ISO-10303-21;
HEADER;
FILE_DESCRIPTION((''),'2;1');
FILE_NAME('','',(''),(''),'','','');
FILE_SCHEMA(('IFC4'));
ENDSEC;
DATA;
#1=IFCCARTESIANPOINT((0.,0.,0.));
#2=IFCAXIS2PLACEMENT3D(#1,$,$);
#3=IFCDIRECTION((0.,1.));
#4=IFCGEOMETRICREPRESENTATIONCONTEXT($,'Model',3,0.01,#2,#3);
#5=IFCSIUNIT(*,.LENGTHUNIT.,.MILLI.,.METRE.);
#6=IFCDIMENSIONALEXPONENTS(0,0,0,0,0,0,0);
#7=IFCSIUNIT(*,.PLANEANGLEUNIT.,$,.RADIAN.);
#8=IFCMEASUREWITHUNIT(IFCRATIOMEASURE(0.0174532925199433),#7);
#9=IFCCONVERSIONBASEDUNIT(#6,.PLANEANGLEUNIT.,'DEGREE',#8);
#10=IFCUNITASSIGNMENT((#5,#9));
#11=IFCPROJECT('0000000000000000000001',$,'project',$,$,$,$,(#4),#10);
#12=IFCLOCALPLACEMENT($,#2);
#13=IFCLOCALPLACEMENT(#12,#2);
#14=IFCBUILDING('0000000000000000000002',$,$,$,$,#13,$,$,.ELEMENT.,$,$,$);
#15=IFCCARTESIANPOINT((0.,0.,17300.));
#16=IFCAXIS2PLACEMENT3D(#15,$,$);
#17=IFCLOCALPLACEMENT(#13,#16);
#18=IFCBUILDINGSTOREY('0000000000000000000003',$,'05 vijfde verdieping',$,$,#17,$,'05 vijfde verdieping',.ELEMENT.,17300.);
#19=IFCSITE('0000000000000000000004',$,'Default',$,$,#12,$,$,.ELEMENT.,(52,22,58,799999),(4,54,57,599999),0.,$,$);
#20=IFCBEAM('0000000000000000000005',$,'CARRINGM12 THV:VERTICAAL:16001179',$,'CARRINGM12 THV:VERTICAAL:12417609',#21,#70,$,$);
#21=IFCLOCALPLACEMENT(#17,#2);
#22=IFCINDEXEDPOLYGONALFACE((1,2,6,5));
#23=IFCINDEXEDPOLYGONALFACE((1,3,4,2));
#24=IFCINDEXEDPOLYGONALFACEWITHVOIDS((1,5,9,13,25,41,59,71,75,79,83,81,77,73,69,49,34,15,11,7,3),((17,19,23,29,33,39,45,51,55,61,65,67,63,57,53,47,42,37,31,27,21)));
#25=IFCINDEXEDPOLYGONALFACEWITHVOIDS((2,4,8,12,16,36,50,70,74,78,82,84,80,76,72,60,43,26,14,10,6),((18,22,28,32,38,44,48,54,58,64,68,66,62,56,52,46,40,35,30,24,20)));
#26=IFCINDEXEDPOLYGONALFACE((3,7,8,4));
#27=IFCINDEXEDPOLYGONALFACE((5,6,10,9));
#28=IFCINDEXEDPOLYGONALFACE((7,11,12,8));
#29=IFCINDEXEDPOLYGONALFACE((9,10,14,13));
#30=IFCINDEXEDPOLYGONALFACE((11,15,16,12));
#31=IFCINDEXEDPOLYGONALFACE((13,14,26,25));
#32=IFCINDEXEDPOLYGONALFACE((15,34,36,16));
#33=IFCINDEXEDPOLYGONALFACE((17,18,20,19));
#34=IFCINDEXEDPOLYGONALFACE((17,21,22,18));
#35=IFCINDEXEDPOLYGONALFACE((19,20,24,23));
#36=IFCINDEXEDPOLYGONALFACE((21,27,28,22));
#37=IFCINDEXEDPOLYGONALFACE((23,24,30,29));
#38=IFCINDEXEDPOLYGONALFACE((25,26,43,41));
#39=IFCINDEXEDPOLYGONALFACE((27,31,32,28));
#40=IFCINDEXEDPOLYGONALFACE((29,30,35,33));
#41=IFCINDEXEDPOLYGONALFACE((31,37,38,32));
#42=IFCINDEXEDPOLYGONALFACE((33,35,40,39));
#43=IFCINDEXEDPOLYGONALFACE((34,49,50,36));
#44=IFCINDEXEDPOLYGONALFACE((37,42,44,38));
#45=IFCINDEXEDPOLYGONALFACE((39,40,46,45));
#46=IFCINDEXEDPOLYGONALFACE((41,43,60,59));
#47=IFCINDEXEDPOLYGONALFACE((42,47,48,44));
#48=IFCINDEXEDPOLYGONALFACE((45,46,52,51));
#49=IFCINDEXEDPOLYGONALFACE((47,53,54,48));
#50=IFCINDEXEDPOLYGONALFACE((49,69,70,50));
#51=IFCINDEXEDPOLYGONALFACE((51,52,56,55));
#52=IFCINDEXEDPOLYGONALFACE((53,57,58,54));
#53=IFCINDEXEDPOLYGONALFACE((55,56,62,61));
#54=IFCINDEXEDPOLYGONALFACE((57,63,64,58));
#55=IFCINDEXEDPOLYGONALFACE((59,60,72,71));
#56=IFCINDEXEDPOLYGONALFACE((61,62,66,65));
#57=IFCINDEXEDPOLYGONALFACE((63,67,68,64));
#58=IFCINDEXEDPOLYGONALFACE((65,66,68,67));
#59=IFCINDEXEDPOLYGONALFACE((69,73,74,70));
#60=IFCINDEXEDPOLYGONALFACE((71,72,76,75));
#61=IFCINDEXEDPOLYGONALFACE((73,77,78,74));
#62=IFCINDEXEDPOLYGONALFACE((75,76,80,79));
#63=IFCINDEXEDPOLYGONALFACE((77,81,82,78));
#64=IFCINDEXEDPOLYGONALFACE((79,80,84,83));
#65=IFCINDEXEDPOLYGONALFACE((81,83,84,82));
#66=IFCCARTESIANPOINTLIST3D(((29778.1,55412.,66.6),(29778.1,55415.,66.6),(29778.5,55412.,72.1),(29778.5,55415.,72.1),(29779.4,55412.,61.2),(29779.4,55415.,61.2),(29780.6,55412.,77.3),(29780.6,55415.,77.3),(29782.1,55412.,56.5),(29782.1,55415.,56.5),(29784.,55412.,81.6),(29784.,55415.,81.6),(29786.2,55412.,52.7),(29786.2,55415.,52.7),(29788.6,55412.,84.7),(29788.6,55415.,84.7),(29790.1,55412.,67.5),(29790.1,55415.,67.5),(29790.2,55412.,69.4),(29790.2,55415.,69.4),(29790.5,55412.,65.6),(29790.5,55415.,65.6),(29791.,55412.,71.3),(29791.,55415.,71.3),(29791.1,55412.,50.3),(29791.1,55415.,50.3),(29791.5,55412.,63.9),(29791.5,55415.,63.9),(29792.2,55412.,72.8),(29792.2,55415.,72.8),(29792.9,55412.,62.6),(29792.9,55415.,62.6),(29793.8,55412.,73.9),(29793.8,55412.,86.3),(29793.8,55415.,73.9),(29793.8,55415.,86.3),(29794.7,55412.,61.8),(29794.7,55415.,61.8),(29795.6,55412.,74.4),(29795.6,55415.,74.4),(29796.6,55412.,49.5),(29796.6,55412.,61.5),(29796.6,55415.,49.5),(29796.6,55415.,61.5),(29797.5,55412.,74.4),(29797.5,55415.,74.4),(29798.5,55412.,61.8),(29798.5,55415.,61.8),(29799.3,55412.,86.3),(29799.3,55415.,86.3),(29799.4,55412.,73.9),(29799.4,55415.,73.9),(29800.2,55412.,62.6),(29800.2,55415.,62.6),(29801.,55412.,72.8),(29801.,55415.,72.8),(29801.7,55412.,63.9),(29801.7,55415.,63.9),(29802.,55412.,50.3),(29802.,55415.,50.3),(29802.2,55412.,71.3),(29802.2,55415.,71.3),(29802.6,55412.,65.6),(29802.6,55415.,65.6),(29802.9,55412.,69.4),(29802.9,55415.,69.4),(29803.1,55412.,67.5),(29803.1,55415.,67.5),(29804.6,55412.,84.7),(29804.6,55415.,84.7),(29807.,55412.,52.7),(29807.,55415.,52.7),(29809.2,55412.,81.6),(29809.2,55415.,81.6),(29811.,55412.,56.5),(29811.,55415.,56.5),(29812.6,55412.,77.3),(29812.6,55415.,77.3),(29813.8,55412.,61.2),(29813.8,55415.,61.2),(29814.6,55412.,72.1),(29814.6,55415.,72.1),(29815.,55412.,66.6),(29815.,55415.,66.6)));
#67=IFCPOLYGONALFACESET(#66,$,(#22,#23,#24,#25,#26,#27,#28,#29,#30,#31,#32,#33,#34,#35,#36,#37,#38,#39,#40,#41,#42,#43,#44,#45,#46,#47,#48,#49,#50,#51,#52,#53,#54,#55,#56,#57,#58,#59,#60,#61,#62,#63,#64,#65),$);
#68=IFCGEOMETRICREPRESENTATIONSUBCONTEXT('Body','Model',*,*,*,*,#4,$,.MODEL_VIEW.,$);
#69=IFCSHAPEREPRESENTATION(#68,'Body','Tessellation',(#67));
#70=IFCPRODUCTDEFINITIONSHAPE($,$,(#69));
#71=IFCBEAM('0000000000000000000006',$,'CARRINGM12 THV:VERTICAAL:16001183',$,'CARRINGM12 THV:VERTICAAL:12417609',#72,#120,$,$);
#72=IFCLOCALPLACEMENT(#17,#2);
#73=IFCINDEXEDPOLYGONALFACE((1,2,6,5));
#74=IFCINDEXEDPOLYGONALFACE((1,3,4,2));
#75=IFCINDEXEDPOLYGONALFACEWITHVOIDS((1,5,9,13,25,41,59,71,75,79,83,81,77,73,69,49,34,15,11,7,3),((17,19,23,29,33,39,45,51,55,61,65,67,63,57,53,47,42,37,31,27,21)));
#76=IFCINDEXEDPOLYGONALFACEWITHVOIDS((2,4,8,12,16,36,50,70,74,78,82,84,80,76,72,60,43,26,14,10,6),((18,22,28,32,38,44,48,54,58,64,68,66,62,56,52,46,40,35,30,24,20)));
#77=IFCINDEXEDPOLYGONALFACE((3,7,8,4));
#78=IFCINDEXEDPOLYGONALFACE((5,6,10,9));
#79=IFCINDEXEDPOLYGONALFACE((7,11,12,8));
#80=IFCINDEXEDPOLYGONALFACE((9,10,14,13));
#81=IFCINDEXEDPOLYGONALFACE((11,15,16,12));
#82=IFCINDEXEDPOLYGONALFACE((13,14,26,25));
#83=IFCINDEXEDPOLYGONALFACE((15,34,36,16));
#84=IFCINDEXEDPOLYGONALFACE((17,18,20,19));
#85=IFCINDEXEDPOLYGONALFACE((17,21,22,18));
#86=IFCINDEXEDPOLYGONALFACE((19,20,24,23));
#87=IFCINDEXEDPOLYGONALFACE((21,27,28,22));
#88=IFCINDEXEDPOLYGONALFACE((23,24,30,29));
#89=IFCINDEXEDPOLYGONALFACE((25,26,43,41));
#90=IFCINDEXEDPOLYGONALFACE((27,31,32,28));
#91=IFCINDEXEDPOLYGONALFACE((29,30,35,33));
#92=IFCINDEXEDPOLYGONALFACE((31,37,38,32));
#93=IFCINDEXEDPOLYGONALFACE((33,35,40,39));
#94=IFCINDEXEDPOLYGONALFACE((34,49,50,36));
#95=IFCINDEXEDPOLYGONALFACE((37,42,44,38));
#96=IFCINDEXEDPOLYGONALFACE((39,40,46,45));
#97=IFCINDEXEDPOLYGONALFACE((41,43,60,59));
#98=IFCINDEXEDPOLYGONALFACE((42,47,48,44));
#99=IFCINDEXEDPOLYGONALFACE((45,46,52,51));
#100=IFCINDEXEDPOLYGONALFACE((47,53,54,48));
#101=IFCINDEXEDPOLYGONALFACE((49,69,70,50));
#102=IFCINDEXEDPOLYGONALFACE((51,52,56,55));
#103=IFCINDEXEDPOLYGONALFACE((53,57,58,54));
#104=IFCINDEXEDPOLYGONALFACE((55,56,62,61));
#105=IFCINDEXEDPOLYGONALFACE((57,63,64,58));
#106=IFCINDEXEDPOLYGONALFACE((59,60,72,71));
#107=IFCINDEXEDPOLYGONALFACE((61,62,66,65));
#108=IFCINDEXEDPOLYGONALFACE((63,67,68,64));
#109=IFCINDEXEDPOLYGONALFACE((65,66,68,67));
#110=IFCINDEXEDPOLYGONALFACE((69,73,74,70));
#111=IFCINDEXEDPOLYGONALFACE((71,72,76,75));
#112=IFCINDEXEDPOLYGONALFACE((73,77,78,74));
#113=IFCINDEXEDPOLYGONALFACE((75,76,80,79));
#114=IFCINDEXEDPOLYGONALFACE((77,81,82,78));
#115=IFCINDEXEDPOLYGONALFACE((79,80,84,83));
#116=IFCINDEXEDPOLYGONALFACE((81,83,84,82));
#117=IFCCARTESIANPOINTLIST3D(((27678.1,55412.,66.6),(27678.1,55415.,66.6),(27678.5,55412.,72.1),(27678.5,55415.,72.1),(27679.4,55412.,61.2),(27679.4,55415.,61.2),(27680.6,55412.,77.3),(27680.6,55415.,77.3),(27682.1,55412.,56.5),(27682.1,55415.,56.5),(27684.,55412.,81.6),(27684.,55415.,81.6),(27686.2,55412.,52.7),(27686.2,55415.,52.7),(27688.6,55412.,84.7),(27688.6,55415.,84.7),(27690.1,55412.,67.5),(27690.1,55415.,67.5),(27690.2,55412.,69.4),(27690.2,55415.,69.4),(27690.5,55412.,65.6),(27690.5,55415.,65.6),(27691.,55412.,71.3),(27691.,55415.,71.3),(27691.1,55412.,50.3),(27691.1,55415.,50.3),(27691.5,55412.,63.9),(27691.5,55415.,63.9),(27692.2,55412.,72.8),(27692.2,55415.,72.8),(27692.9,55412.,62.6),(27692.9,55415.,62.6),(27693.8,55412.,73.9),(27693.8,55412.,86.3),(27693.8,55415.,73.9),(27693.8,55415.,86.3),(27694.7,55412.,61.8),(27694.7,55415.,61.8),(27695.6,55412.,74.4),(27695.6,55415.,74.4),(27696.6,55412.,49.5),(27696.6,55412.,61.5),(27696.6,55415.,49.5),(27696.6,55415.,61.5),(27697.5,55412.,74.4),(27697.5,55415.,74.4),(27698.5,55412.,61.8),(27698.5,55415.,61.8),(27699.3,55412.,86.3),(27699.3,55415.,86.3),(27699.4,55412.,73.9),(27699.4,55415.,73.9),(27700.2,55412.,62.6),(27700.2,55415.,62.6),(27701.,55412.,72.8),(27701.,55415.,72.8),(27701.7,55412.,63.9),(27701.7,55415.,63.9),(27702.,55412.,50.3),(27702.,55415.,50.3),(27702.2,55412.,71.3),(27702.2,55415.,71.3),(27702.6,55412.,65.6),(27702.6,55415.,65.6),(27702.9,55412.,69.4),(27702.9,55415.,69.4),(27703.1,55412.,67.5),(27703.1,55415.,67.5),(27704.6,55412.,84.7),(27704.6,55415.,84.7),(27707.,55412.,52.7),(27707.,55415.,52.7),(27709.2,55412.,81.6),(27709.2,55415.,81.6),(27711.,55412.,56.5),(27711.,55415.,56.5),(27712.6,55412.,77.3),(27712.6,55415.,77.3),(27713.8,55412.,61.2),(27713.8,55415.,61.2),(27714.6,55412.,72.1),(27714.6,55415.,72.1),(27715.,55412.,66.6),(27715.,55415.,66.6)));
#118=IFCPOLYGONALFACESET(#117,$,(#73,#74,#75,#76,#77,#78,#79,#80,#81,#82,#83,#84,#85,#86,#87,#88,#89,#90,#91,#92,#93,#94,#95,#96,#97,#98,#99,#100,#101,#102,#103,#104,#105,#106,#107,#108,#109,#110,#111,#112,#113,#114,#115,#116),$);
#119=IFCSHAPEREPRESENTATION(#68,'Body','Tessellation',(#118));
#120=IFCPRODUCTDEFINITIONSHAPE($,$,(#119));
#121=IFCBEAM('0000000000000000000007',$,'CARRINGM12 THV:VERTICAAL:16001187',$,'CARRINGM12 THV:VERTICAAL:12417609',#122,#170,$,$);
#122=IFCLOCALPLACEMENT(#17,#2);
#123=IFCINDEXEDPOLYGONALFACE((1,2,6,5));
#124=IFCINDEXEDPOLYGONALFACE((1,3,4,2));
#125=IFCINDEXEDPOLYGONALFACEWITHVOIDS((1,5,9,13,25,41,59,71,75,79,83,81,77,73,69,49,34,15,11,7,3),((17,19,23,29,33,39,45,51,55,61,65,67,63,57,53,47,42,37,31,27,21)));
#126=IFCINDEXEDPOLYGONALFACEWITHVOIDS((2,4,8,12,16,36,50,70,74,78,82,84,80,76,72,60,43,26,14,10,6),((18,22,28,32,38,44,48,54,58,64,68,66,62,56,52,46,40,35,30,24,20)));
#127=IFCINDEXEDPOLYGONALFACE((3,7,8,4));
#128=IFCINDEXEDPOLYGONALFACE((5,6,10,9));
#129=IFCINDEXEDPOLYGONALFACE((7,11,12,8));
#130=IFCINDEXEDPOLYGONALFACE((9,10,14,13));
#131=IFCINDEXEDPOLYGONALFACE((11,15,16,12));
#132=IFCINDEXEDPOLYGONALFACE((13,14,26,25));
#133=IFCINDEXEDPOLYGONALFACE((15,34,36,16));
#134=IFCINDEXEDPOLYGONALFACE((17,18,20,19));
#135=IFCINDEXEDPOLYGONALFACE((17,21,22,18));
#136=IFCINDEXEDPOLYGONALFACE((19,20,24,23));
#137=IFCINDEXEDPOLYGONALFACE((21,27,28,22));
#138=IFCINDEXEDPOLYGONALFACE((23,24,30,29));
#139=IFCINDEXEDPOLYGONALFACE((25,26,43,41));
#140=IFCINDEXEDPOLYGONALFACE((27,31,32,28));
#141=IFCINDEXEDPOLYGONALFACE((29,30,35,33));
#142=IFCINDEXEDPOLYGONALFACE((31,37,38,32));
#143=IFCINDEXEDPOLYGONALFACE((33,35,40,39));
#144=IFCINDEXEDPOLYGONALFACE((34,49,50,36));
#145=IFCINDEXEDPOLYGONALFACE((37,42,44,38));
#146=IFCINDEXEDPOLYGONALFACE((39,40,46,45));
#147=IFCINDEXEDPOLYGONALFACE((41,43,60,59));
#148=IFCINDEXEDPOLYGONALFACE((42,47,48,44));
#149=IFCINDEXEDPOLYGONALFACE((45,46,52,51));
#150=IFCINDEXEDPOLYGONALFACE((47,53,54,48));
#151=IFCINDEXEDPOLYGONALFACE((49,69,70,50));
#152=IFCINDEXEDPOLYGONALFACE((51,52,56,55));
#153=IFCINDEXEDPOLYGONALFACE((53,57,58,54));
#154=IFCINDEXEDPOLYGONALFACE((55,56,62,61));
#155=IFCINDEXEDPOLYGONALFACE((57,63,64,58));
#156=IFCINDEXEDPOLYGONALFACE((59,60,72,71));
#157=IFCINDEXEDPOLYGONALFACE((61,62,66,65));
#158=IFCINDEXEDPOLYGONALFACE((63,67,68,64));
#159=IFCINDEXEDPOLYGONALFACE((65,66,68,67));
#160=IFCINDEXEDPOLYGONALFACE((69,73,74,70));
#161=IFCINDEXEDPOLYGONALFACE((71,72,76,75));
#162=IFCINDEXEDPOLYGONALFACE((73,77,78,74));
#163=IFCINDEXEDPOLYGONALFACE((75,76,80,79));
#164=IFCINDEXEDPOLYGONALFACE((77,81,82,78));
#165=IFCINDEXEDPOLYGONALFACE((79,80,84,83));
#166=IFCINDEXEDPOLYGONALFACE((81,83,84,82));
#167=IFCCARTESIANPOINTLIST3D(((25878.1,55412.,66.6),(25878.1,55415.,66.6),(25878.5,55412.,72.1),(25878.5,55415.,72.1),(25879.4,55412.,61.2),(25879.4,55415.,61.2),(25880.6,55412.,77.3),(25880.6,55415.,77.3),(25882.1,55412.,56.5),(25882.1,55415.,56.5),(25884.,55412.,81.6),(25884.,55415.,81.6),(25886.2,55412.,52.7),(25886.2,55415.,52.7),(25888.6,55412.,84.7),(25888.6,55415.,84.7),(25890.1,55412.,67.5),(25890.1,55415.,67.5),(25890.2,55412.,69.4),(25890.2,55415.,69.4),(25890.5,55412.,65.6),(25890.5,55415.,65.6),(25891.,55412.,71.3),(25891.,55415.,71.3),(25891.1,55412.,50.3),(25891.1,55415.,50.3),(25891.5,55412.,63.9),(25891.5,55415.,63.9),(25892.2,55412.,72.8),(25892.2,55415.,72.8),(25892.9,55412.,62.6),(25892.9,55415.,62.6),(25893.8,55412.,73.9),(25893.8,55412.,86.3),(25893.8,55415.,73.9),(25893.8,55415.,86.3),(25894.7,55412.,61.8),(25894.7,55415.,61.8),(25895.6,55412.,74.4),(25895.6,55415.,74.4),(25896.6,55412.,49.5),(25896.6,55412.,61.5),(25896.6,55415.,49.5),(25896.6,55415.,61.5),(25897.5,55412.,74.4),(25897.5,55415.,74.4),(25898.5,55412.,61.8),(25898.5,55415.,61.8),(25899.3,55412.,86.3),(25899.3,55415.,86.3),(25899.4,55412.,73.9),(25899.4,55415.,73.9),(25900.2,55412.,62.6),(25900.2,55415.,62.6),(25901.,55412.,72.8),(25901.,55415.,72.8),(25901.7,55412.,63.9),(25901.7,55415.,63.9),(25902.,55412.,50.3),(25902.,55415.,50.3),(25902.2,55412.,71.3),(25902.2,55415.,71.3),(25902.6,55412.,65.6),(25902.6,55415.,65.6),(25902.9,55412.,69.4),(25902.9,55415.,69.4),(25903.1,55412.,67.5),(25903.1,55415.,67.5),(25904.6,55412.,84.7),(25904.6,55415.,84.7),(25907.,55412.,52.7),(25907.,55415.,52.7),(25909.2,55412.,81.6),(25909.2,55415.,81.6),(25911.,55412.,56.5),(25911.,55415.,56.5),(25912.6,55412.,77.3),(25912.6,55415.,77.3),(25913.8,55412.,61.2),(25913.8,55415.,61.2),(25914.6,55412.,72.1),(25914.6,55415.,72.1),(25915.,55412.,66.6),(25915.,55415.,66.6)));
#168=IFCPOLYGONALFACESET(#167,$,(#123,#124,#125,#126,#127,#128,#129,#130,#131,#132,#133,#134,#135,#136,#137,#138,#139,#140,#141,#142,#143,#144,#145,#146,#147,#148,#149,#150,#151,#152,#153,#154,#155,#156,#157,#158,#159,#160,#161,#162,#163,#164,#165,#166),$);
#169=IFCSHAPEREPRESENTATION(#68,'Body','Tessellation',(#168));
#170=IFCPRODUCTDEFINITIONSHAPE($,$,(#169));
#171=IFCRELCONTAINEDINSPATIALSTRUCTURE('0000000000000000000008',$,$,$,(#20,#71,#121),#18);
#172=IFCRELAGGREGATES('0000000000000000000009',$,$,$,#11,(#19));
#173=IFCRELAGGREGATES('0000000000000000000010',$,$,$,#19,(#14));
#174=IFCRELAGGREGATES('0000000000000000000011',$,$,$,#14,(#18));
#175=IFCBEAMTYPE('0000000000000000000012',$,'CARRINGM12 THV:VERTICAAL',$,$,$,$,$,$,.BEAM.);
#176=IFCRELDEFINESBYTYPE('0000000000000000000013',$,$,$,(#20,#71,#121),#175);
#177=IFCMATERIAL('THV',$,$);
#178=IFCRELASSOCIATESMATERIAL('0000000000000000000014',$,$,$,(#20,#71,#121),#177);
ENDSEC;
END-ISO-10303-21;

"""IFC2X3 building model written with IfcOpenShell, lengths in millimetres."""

from ifc_helpers import new_model, entity, si_unit, converted_unit, direction, frame, origin, origin_2d_with_axis, place, context, subcontext, project, spatial, hollow_circle, extrude, material, type_object, element, save


model = new_model("IFC2X3")

# Units and contexts
model_context = context("Model", 3, precision=0.01, world=origin(), true_north=direction((0.0, 1.0)))
body_context = subcontext(model_context, "Body", "Model", "MODEL_VIEW")
ifc_project = project(units=[si_unit("LENGTHUNIT", "METRE", prefix="MILLI"), converted_unit("PLANEANGLEUNIT", "DEGREE", entity("IfcRatioMeasure", 0.0174532925199433), si_unit("PLANEANGLEUNIT", "RADIAN"), dimensions=[0, 0, 0, 0, 0, 0, 0])], contexts=[model_context])

# Site, building, storey
site_placement = place(None, origin())
site = spatial("IfcSite", under=ifc_project, at=site_placement, Name="Default", CompositionType="ELEMENT", RefLatitude=(52, 22, 58, 799999), RefLongitude=(4, 54, 57, 599999), RefElevation=0.0)
building_placement = place(site_placement, origin())
building = spatial("IfcBuilding", under=site, at=building_placement, CompositionType="ELEMENT")
storey_placement = place(building_placement, frame((0.0, 0.0, 17300.0)))
storey = spatial("IfcBuildingStorey", under=building, at=storey_placement, Name="05 vijfde verdieping", LongName="05 vijfde verdieping", CompositionType="ELEMENT", Elevation=17300.0)

# Beams
ifc_material_1 = material(Name="THV")
beam_type_1 = type_object("IfcBeamType", Name="CARRINGM12 THV:VERTICAAL", PredefinedType="BEAM")
beam_1_placement = place(storey_placement, origin())
element("IfcBeam", 1, at=beam_1_placement, inside=storey, type_object=beam_type_1, material=ifc_material_1, Name="CARRINGM12 THV:VERTICAAL:16001179", ObjectType="CARRINGM12 THV:VERTICAAL:12417609", context=body_context, shape_type="SweptSolid", body=[
    extrude(hollow_circle(Radius=18.5, WallThickness=12.0, at=origin_2d_with_axis()), frame((29796.6, 55412.0, 68.0), z_axis=(0.0, 1.0, 0.0), x_axis=(0.0, 0.0, -1.0)), (0.0, 0.0, 1.0), 3.0),
])
beam_2_placement = place(storey_placement, origin())
element("IfcBeam", 2, at=beam_2_placement, inside=storey, type_object=beam_type_1, material=ifc_material_1, Name="CARRINGM12 THV:VERTICAAL:16001183", ObjectType="CARRINGM12 THV:VERTICAAL:12417609", context=body_context, shape_type="SweptSolid", body=[
    extrude(hollow_circle(Radius=18.5, WallThickness=12.0, at=origin_2d_with_axis()), frame((27696.6, 55412.0, 68.0), z_axis=(0.0, 1.0, 0.0), x_axis=(0.0, 0.0, -1.0)), (0.0, 0.0, 1.0), 3.0),
])
beam_3_placement = place(storey_placement, origin())
element("IfcBeam", 3, at=beam_3_placement, inside=storey, type_object=beam_type_1, material=ifc_material_1, Name="CARRINGM12 THV:VERTICAAL:16001187", ObjectType="CARRINGM12 THV:VERTICAAL:12417609", context=body_context, shape_type="SweptSolid", body=[
    extrude(hollow_circle(Radius=18.5, WallThickness=12.0, at=origin_2d_with_axis()), frame((25896.6, 55412.0, 68.0), z_axis=(0.0, 1.0, 0.0), x_axis=(0.0, 0.0, -1.0)), (0.0, 0.0, 1.0), 3.0),
])

save(model, "model.ifc")
